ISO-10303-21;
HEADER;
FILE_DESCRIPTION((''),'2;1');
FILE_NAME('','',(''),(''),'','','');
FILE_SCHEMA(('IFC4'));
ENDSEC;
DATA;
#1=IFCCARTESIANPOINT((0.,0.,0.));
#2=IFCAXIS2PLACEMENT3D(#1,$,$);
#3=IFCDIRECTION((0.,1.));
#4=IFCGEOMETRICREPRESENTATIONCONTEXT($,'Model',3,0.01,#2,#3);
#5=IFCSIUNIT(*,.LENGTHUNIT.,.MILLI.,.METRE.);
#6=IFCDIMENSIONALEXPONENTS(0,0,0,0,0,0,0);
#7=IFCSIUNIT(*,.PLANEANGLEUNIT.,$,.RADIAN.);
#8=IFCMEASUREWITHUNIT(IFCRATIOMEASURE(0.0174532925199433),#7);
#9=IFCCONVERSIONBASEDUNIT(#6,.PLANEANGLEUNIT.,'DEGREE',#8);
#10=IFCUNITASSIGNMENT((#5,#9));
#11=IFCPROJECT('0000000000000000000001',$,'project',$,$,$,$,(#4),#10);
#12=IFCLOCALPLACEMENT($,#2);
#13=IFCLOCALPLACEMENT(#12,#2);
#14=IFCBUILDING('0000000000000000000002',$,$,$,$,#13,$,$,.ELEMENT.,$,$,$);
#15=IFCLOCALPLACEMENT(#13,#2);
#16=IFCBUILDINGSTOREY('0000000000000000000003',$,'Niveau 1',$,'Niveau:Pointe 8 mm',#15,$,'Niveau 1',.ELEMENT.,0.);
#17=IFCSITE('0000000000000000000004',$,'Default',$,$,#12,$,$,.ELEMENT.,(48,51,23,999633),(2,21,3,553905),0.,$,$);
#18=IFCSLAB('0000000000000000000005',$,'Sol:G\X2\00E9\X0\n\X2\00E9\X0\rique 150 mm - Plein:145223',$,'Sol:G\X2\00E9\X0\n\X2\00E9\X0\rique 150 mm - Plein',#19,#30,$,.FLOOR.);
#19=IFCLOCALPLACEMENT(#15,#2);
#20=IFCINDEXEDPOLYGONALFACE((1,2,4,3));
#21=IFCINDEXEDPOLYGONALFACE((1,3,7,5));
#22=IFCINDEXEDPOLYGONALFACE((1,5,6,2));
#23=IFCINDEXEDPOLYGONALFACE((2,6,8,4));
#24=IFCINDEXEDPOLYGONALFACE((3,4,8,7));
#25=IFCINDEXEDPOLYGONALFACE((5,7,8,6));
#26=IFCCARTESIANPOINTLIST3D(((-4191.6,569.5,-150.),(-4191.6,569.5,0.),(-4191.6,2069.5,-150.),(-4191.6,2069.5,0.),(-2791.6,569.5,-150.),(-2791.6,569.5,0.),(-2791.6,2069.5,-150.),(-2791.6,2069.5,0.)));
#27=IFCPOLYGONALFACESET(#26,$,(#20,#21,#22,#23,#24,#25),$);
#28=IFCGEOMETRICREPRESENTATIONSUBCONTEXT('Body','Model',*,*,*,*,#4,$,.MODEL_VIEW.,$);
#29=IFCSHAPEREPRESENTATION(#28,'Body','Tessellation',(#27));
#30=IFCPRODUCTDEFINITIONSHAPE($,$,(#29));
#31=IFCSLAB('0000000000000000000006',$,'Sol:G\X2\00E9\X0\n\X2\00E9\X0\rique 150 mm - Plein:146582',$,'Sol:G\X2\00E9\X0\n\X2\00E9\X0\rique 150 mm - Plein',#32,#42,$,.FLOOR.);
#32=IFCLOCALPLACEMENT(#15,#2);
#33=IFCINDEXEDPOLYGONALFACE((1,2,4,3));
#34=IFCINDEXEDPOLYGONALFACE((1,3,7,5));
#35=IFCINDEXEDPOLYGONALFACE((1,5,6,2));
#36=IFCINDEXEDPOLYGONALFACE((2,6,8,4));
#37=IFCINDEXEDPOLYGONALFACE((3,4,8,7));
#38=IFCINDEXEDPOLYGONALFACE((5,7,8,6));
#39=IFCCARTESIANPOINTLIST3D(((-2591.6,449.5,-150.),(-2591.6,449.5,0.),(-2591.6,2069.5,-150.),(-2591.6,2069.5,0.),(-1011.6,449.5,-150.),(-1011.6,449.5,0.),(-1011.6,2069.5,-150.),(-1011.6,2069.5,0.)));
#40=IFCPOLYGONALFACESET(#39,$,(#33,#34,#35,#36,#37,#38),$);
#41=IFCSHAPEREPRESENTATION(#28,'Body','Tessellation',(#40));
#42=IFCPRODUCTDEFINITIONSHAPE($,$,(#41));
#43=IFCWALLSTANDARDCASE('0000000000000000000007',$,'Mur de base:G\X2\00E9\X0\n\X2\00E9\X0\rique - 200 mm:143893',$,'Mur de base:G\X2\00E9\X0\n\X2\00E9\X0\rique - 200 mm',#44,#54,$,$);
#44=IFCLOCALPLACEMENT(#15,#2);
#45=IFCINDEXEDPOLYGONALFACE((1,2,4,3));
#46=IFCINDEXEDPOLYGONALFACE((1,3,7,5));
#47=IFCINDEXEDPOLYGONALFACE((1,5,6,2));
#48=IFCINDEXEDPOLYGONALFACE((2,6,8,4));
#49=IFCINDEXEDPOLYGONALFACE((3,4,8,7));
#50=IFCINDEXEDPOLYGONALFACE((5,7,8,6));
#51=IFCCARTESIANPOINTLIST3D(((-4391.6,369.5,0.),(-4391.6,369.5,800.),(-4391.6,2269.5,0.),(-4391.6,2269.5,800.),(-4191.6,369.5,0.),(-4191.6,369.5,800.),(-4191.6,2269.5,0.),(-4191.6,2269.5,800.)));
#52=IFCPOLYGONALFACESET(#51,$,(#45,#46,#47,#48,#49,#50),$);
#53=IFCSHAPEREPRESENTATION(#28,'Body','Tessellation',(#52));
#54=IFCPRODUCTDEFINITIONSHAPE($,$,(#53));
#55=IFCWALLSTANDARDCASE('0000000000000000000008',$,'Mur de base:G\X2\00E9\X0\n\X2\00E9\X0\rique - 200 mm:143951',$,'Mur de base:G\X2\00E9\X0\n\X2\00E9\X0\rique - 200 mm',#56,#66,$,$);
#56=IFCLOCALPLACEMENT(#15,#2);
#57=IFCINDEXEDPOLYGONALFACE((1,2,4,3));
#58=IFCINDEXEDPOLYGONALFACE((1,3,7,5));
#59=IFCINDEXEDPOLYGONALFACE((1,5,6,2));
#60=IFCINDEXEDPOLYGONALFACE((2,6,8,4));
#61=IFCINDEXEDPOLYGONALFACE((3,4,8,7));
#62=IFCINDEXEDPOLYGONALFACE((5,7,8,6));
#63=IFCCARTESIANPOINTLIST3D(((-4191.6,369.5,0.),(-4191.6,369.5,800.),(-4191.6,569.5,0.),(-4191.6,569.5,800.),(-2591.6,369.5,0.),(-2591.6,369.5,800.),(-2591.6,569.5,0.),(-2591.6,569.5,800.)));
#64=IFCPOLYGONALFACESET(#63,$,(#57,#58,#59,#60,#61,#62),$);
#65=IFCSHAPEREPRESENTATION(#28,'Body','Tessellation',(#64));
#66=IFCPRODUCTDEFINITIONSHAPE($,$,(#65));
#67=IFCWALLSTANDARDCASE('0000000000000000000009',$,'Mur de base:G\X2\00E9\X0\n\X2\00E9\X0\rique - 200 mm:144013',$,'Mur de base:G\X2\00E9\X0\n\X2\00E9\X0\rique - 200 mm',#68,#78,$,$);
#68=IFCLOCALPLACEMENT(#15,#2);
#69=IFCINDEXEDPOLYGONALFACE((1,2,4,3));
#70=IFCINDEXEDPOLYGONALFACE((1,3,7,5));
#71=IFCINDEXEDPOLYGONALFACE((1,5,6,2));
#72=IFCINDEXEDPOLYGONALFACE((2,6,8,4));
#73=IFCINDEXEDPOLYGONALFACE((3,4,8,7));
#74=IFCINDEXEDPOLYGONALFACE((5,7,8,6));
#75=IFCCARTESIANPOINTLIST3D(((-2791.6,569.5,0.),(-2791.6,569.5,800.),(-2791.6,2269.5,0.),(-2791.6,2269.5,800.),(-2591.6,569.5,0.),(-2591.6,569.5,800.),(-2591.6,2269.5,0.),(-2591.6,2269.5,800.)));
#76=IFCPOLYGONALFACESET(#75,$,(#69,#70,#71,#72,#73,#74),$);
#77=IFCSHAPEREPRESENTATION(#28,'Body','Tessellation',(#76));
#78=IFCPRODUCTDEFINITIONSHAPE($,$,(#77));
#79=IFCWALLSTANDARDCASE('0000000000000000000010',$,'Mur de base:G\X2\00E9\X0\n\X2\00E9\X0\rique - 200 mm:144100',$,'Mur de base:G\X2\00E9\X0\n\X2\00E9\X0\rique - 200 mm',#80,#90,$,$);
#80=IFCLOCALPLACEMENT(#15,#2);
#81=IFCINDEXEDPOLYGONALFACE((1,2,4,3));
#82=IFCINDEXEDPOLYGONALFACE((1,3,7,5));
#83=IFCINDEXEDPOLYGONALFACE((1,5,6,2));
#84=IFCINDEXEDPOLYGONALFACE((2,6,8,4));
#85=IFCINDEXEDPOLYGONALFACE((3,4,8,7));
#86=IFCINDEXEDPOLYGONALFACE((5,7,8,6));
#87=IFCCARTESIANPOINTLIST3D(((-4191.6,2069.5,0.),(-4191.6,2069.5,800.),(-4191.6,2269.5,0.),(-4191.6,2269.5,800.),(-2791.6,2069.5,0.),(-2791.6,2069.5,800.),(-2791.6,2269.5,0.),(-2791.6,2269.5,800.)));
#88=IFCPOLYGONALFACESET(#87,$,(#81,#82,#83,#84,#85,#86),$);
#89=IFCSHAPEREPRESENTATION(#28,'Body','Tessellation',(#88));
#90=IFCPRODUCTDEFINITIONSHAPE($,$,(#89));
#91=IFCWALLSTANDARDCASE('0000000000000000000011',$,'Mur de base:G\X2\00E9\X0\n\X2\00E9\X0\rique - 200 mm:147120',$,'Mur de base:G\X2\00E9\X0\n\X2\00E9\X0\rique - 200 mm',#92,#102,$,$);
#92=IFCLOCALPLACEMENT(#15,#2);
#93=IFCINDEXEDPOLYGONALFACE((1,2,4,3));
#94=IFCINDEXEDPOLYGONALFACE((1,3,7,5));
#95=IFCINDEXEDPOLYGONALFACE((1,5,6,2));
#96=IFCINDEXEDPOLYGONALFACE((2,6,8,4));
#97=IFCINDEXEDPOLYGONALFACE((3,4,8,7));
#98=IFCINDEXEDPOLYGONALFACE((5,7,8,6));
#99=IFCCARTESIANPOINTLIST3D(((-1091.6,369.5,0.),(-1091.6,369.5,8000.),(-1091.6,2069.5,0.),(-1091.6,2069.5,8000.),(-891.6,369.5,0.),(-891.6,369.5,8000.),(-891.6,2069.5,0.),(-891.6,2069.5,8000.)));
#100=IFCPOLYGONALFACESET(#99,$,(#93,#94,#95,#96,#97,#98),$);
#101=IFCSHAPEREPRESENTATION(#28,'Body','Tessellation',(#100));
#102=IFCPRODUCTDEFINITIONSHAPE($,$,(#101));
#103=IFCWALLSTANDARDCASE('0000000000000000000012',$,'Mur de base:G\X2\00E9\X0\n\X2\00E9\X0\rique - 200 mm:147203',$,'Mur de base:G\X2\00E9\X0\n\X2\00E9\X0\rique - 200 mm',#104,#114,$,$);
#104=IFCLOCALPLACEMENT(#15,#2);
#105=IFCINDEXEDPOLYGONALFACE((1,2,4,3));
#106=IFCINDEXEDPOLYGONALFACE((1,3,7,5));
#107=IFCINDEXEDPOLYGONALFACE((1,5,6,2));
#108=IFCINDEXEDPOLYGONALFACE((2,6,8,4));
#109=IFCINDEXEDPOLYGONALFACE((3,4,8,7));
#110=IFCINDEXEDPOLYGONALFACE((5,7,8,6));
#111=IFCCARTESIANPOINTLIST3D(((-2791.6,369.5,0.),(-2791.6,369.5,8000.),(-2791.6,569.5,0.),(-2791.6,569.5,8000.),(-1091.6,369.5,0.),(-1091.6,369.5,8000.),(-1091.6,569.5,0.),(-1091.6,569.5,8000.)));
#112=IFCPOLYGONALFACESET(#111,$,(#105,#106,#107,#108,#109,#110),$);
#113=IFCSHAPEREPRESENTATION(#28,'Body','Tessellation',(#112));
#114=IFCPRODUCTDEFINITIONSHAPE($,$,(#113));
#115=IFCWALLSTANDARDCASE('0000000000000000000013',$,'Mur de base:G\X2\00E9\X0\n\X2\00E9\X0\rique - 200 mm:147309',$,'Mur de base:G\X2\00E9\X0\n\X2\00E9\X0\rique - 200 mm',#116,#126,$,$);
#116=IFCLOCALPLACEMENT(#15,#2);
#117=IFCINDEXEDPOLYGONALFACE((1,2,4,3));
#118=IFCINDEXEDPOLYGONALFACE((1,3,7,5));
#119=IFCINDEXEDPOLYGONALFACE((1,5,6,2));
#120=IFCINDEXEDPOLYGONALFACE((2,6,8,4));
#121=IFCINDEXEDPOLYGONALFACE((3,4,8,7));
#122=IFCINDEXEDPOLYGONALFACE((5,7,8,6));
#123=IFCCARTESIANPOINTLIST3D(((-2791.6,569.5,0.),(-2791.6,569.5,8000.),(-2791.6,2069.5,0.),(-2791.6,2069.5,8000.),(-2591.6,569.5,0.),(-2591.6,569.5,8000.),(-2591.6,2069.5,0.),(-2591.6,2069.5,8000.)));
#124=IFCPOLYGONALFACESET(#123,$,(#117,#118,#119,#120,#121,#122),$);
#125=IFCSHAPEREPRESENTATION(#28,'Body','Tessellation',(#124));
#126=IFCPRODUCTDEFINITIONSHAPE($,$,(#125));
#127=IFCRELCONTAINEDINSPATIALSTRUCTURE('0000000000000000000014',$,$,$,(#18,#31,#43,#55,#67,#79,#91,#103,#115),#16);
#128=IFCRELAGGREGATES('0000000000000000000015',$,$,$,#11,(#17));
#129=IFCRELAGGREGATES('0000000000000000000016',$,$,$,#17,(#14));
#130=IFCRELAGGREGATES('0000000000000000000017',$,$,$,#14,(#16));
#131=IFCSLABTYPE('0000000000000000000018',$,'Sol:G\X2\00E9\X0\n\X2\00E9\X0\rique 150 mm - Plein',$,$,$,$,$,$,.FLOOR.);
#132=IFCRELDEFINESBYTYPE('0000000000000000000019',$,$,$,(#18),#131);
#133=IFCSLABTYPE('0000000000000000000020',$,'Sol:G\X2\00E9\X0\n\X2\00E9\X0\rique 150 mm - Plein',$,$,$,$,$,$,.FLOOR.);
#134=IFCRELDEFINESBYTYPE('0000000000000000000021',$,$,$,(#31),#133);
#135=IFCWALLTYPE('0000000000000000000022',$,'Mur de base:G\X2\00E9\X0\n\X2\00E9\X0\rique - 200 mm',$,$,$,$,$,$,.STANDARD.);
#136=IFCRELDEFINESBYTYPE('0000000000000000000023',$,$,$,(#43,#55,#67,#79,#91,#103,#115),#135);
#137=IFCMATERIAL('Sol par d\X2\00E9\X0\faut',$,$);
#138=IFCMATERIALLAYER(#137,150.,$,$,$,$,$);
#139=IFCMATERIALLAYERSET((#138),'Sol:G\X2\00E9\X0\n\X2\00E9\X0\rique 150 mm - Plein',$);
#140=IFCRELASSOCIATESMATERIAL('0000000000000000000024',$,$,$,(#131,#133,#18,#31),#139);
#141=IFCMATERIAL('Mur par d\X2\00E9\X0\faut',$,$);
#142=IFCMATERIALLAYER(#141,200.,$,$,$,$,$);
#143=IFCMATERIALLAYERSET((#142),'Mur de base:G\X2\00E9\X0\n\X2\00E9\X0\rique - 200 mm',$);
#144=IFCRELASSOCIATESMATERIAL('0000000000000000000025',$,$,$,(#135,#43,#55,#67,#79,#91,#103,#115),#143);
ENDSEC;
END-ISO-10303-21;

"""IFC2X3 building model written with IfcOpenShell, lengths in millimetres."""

from ifc_helpers import new_model, entity, si_unit, converted_unit, direction, frame, frame_2d, origin, origin_2d_with_axis, place, context, subcontext, project, spatial, rectangle, extrude, material, layer, layer_set, layer_usage, type_object, element, save


model = new_model("IFC2X3")

# Units and contexts
model_context = context("Model", 3, precision=0.01, world=origin(), true_north=direction((0.0, 1.0)))
body_context = subcontext(model_context, "Body", "Model", "MODEL_VIEW")
ifc_project = project(units=[si_unit("LENGTHUNIT", "METRE", prefix="MILLI"), converted_unit("PLANEANGLEUNIT", "DEGREE", entity("IfcRatioMeasure", 0.0174532925199433), si_unit("PLANEANGLEUNIT", "RADIAN"), dimensions=[0, 0, 0, 0, 0, 0, 0])], contexts=[model_context])

# Site, building, storey
site_placement = place(None, origin())
site = spatial("IfcSite", under=ifc_project, at=site_placement, Name="Default", CompositionType="ELEMENT", RefLatitude=(48, 51, 23, 999633), RefLongitude=(2, 21, 3, 553905), RefElevation=0.0)
building_placement = place(site_placement, origin())
building = spatial("IfcBuilding", under=site, at=building_placement, CompositionType="ELEMENT")
storey_placement = place(building_placement, origin())
storey = spatial("IfcBuildingStorey", under=building, at=storey_placement, Name="Niveau 1", ObjectType="Niveau:Pointe 8 mm", LongName="Niveau 1", CompositionType="ELEMENT", Elevation=0.0)

# Slabs
ifc_material_1 = material(Name="Sol par défaut")
ifc_layer_1 = layer(ifc_material_1, 150.0)
ifc_layer_set_1 = layer_set([ifc_layer_1], Name="Sol:Générique 150 mm - Plein")
ifc_layer_usage_1 = layer_usage(ifc_layer_set_1, "AXIS3", "POSITIVE", 0.0)
slab_type_1 = type_object("IfcSlabType", Name="Sol:Générique 150 mm - Plein", PredefinedType="FLOOR", material=ifc_layer_set_1)
slab_1_placement = place(storey_placement, origin())
element("IfcSlab", 1, at=slab_1_placement, inside=storey, type_object=slab_type_1, material=ifc_layer_usage_1, Name="Sol:Générique 150 mm - Plein:145223", ObjectType="Sol:Générique 150 mm - Plein", PredefinedType="FLOOR", context=body_context, shape_type="SweptSolid", body=[
    extrude(rectangle(XDim=1500.0, YDim=1400.0, at=frame_2d((0.0, 0.0), x_axis=(1.0, 0.0))), frame((-3491.6, 1319.5, 0.0), z_axis=(0.0, 0.0, -1.0), x_axis=(0.0, 1.0, 0.0)), (0.0, 0.0, 1.0), 150.0),
])
ifc_layer_usage_2 = layer_usage(ifc_layer_set_1, "AXIS3", "POSITIVE", 0.0)
slab_type_2 = type_object("IfcSlabType", Name="Sol:Générique 150 mm - Plein", PredefinedType="FLOOR", material=ifc_layer_set_1)
slab_2_placement = place(storey_placement, origin())
element("IfcSlab", 2, at=slab_2_placement, inside=storey, type_object=slab_type_2, material=ifc_layer_usage_2, Name="Sol:Générique 150 mm - Plein:146582", ObjectType="Sol:Générique 150 mm - Plein", PredefinedType="FLOOR", context=body_context, shape_type="SweptSolid", body=[
    extrude(rectangle(XDim=1620.0, YDim=1580.0, at=origin_2d_with_axis()), frame((-1801.6, 1259.5, 0.0), z_axis=(0.0, 0.0, -1.0), x_axis=(0.0, 1.0, 0.0)), (0.0, 0.0, 1.0), 150.0),
])

# Walls
ifc_material_2 = material(Name="Mur par défaut")
ifc_layer_2 = layer(ifc_material_2, 200.0)
ifc_layer_set_2 = layer_set([ifc_layer_2], Name="Mur de base:Générique - 200 mm")
ifc_layer_usage_3 = layer_usage(ifc_layer_set_2, "AXIS2", "NEGATIVE", 100.0)
wall_type = type_object("IfcWallType", Name="Mur de base:Générique - 200 mm", PredefinedType="STANDARD", material=ifc_layer_set_2)
wall_1_placement = place(storey_placement, frame((-4291.6, 2269.5, 0.0), z_axis=(0.0, 0.0, 1.0), x_axis=(0.0, -1.0, 0.0)))
element("IfcWallStandardCase", 3, at=wall_1_placement, inside=storey, type_object=wall_type, material=ifc_layer_usage_3, Name="Mur de base:Générique - 200 mm:143893", ObjectType="Mur de base:Générique - 200 mm", context=body_context, shape_type="SweptSolid", body=[
    extrude(rectangle(XDim=1900.0, YDim=200.0, at=frame_2d((950.0, 0.0), x_axis=(-1.0, 0.0))), origin(), (0.0, 0.0, 1.0), 800.0),
])
ifc_layer_usage_4 = layer_usage(ifc_layer_set_2, "AXIS2", "NEGATIVE", 100.0)
wall_2_placement = place(storey_placement, frame((-4191.6, 469.5, 0.0)))
element("IfcWallStandardCase", 4, at=wall_2_placement, inside=storey, type_object=wall_type, material=ifc_layer_usage_4, Name="Mur de base:Générique - 200 mm:143951", ObjectType="Mur de base:Générique - 200 mm", context=body_context, shape_type="SweptSolid", body=[
    extrude(rectangle(XDim=1600.0, YDim=200.0, at=frame_2d((800.0, 0.0), x_axis=(-1.0, 0.0))), origin(), (0.0, 0.0, 1.0), 800.0),
])
ifc_layer_usage_5 = layer_usage(ifc_layer_set_2, "AXIS2", "NEGATIVE", 100.0)
wall_3_placement = place(storey_placement, frame((-2691.6, 569.5, 0.0), z_axis=(0.0, 0.0, 1.0), x_axis=(0.0, 1.0, 0.0)))
element("IfcWallStandardCase", 5, at=wall_3_placement, inside=storey, type_object=wall_type, material=ifc_layer_usage_5, Name="Mur de base:Générique - 200 mm:144013", ObjectType="Mur de base:Générique - 200 mm", context=body_context, shape_type="SweptSolid", body=[
    extrude(rectangle(XDim=1700.0, YDim=200.0, at=frame_2d((850.0, 0.0), x_axis=(-1.0, 0.0))), origin(), (0.0, 0.0, 1.0), 800.0),
])
ifc_layer_usage_6 = layer_usage(ifc_layer_set_2, "AXIS2", "NEGATIVE", 100.0)
wall_4_placement = place(storey_placement, frame((-2791.6, 2169.5, 0.0), z_axis=(0.0, 0.0, 1.0), x_axis=(-1.0, 0.0, 0.0)))
element("IfcWallStandardCase", 6, at=wall_4_placement, inside=storey, type_object=wall_type, material=ifc_layer_usage_6, Name="Mur de base:Générique - 200 mm:144100", ObjectType="Mur de base:Générique - 200 mm", context=body_context, shape_type="SweptSolid", body=[
    extrude(rectangle(XDim=1400.0, YDim=200.0, at=frame_2d((700.0, 0.0), x_axis=(-1.0, 0.0))), origin(), (0.0, 0.0, 1.0), 800.0),
])
ifc_layer_usage_7 = layer_usage(ifc_layer_set_2, "AXIS2", "NEGATIVE", 100.0)
wall_5_placement = place(storey_placement, frame((-991.6, 2069.5, 0.0), z_axis=(0.0, 0.0, 1.0), x_axis=(0.0, -1.0, 0.0)))
element("IfcWallStandardCase", 7, at=wall_5_placement, inside=storey, type_object=wall_type, material=ifc_layer_usage_7, Name="Mur de base:Générique - 200 mm:147120", ObjectType="Mur de base:Générique - 200 mm", context=body_context, shape_type="SweptSolid", body=[
    extrude(rectangle(XDim=1700.0, YDim=200.0, at=frame_2d((850.0, 0.0), x_axis=(-1.0, 0.0))), origin(), (0.0, 0.0, 1.0), 8000.0),
])
ifc_layer_usage_8 = layer_usage(ifc_layer_set_2, "AXIS2", "NEGATIVE", 100.0)
wall_6_placement = place(storey_placement, frame((-1091.6, 469.5, 0.0), z_axis=(0.0, 0.0, 1.0), x_axis=(-1.0, 0.0, 0.0)))
element("IfcWallStandardCase", 8, at=wall_6_placement, inside=storey, type_object=wall_type, material=ifc_layer_usage_8, Name="Mur de base:Générique - 200 mm:147203", ObjectType="Mur de base:Générique - 200 mm", context=body_context, shape_type="SweptSolid", body=[
    extrude(rectangle(XDim=1700.0, YDim=200.0, at=frame_2d((850.0, 0.0), x_axis=(-1.0, 0.0))), origin(), (0.0, 0.0, 1.0), 8000.0),
])
ifc_layer_usage_9 = layer_usage(ifc_layer_set_2, "AXIS2", "NEGATIVE", 100.0)
wall_7_placement = place(storey_placement, frame((-2691.6, 569.5, 0.0), z_axis=(0.0, 0.0, 1.0), x_axis=(0.0, 1.0, 0.0)))
element("IfcWallStandardCase", 9, at=wall_7_placement, inside=storey, type_object=wall_type, material=ifc_layer_usage_9, Name="Mur de base:Générique - 200 mm:147309", ObjectType="Mur de base:Générique - 200 mm", context=body_context, shape_type="SweptSolid", body=[
    extrude(rectangle(XDim=1500.0, YDim=200.0, at=frame_2d((750.0, 0.0), x_axis=(-1.0, 0.0))), origin(), (0.0, 0.0, 1.0), 8000.0),
])

save(model, "model.ifc")
